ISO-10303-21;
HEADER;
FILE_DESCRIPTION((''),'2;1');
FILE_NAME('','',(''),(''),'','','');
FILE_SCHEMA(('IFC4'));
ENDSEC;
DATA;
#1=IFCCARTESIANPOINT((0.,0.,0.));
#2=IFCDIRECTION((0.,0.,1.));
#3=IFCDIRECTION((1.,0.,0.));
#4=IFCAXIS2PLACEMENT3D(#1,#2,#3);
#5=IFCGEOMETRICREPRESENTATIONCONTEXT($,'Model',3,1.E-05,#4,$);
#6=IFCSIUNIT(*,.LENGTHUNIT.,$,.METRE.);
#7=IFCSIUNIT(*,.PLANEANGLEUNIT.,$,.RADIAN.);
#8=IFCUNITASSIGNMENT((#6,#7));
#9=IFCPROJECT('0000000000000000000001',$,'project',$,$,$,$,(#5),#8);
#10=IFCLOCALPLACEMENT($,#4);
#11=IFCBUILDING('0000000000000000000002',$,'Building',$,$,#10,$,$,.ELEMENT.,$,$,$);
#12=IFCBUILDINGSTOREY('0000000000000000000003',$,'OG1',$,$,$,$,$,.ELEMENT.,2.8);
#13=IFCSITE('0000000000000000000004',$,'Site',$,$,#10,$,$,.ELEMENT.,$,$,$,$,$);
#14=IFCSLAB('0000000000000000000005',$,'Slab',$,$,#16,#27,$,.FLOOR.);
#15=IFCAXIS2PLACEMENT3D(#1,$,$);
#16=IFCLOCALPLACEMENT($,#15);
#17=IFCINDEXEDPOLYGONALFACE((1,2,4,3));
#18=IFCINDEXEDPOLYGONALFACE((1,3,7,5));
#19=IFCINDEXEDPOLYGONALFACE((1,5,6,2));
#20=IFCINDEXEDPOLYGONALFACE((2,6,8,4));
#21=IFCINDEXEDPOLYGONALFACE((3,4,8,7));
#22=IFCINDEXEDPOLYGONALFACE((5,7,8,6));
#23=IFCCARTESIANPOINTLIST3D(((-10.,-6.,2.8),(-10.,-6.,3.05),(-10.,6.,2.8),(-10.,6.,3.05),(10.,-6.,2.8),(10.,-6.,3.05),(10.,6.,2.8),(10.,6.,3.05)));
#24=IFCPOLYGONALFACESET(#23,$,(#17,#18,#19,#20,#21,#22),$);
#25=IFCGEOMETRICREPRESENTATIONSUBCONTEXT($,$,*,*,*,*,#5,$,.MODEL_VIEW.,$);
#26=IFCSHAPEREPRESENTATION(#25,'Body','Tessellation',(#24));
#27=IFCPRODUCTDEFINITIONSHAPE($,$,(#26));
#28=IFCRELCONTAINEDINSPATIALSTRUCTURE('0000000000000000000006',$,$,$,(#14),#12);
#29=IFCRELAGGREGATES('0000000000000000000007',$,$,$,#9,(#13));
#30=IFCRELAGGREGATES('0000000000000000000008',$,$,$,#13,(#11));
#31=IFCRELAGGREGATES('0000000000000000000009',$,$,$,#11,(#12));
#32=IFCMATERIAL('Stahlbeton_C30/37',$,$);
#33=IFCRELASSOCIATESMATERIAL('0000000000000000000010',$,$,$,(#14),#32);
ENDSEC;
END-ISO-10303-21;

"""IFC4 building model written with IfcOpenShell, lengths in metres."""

from ifc_helpers import new_model, si_unit, frame, frame_2d, origin, origin_with_axes, place, context, subcontext, project, spatial, rectangle, extrude, material, element, save


model = new_model("IFC4")

# Units and contexts
model_context = context("Model", 3, precision=1e-05, world=origin_with_axes())
sub_context = subcontext(model_context, None, None, "MODEL_VIEW")
ifc_project = project(units=[si_unit("LENGTHUNIT", "METRE"), si_unit("PLANEANGLEUNIT", "RADIAN")], contexts=[model_context])

# Site, building, storey
placement_1 = place(None, origin_with_axes())
site = spatial("IfcSite", under=ifc_project, at=placement_1, Name="Site", CompositionType="ELEMENT")
building = spatial("IfcBuilding", under=site, at=placement_1, Name="Building", CompositionType="ELEMENT")
storey = spatial("IfcBuildingStorey", under=building, Name="OG1", CompositionType="ELEMENT", Elevation=2.8)

# Slab
ifc_material = material(Name="Stahlbeton_C30/37")
placement_2 = place(None, origin_with_axes())
placement_3 = place(placement_2, frame((0.0, 0.0, 2.8)))
slab_placement = place(placement_3, frame((-10.0, -6.0, 0.0)))
element("IfcSlab", 1, at=slab_placement, inside=storey, material=ifc_material, Name="Slab", PredefinedType="FLOOR", context=sub_context, shape_type="SweptSolid", body=[
    extrude(rectangle(XDim=20.0, YDim=12.0, at=frame_2d((10.0, 6.0))), origin(), (0.0, 0.0, 1.0), 0.25),
])

save(model, "model.ifc")
